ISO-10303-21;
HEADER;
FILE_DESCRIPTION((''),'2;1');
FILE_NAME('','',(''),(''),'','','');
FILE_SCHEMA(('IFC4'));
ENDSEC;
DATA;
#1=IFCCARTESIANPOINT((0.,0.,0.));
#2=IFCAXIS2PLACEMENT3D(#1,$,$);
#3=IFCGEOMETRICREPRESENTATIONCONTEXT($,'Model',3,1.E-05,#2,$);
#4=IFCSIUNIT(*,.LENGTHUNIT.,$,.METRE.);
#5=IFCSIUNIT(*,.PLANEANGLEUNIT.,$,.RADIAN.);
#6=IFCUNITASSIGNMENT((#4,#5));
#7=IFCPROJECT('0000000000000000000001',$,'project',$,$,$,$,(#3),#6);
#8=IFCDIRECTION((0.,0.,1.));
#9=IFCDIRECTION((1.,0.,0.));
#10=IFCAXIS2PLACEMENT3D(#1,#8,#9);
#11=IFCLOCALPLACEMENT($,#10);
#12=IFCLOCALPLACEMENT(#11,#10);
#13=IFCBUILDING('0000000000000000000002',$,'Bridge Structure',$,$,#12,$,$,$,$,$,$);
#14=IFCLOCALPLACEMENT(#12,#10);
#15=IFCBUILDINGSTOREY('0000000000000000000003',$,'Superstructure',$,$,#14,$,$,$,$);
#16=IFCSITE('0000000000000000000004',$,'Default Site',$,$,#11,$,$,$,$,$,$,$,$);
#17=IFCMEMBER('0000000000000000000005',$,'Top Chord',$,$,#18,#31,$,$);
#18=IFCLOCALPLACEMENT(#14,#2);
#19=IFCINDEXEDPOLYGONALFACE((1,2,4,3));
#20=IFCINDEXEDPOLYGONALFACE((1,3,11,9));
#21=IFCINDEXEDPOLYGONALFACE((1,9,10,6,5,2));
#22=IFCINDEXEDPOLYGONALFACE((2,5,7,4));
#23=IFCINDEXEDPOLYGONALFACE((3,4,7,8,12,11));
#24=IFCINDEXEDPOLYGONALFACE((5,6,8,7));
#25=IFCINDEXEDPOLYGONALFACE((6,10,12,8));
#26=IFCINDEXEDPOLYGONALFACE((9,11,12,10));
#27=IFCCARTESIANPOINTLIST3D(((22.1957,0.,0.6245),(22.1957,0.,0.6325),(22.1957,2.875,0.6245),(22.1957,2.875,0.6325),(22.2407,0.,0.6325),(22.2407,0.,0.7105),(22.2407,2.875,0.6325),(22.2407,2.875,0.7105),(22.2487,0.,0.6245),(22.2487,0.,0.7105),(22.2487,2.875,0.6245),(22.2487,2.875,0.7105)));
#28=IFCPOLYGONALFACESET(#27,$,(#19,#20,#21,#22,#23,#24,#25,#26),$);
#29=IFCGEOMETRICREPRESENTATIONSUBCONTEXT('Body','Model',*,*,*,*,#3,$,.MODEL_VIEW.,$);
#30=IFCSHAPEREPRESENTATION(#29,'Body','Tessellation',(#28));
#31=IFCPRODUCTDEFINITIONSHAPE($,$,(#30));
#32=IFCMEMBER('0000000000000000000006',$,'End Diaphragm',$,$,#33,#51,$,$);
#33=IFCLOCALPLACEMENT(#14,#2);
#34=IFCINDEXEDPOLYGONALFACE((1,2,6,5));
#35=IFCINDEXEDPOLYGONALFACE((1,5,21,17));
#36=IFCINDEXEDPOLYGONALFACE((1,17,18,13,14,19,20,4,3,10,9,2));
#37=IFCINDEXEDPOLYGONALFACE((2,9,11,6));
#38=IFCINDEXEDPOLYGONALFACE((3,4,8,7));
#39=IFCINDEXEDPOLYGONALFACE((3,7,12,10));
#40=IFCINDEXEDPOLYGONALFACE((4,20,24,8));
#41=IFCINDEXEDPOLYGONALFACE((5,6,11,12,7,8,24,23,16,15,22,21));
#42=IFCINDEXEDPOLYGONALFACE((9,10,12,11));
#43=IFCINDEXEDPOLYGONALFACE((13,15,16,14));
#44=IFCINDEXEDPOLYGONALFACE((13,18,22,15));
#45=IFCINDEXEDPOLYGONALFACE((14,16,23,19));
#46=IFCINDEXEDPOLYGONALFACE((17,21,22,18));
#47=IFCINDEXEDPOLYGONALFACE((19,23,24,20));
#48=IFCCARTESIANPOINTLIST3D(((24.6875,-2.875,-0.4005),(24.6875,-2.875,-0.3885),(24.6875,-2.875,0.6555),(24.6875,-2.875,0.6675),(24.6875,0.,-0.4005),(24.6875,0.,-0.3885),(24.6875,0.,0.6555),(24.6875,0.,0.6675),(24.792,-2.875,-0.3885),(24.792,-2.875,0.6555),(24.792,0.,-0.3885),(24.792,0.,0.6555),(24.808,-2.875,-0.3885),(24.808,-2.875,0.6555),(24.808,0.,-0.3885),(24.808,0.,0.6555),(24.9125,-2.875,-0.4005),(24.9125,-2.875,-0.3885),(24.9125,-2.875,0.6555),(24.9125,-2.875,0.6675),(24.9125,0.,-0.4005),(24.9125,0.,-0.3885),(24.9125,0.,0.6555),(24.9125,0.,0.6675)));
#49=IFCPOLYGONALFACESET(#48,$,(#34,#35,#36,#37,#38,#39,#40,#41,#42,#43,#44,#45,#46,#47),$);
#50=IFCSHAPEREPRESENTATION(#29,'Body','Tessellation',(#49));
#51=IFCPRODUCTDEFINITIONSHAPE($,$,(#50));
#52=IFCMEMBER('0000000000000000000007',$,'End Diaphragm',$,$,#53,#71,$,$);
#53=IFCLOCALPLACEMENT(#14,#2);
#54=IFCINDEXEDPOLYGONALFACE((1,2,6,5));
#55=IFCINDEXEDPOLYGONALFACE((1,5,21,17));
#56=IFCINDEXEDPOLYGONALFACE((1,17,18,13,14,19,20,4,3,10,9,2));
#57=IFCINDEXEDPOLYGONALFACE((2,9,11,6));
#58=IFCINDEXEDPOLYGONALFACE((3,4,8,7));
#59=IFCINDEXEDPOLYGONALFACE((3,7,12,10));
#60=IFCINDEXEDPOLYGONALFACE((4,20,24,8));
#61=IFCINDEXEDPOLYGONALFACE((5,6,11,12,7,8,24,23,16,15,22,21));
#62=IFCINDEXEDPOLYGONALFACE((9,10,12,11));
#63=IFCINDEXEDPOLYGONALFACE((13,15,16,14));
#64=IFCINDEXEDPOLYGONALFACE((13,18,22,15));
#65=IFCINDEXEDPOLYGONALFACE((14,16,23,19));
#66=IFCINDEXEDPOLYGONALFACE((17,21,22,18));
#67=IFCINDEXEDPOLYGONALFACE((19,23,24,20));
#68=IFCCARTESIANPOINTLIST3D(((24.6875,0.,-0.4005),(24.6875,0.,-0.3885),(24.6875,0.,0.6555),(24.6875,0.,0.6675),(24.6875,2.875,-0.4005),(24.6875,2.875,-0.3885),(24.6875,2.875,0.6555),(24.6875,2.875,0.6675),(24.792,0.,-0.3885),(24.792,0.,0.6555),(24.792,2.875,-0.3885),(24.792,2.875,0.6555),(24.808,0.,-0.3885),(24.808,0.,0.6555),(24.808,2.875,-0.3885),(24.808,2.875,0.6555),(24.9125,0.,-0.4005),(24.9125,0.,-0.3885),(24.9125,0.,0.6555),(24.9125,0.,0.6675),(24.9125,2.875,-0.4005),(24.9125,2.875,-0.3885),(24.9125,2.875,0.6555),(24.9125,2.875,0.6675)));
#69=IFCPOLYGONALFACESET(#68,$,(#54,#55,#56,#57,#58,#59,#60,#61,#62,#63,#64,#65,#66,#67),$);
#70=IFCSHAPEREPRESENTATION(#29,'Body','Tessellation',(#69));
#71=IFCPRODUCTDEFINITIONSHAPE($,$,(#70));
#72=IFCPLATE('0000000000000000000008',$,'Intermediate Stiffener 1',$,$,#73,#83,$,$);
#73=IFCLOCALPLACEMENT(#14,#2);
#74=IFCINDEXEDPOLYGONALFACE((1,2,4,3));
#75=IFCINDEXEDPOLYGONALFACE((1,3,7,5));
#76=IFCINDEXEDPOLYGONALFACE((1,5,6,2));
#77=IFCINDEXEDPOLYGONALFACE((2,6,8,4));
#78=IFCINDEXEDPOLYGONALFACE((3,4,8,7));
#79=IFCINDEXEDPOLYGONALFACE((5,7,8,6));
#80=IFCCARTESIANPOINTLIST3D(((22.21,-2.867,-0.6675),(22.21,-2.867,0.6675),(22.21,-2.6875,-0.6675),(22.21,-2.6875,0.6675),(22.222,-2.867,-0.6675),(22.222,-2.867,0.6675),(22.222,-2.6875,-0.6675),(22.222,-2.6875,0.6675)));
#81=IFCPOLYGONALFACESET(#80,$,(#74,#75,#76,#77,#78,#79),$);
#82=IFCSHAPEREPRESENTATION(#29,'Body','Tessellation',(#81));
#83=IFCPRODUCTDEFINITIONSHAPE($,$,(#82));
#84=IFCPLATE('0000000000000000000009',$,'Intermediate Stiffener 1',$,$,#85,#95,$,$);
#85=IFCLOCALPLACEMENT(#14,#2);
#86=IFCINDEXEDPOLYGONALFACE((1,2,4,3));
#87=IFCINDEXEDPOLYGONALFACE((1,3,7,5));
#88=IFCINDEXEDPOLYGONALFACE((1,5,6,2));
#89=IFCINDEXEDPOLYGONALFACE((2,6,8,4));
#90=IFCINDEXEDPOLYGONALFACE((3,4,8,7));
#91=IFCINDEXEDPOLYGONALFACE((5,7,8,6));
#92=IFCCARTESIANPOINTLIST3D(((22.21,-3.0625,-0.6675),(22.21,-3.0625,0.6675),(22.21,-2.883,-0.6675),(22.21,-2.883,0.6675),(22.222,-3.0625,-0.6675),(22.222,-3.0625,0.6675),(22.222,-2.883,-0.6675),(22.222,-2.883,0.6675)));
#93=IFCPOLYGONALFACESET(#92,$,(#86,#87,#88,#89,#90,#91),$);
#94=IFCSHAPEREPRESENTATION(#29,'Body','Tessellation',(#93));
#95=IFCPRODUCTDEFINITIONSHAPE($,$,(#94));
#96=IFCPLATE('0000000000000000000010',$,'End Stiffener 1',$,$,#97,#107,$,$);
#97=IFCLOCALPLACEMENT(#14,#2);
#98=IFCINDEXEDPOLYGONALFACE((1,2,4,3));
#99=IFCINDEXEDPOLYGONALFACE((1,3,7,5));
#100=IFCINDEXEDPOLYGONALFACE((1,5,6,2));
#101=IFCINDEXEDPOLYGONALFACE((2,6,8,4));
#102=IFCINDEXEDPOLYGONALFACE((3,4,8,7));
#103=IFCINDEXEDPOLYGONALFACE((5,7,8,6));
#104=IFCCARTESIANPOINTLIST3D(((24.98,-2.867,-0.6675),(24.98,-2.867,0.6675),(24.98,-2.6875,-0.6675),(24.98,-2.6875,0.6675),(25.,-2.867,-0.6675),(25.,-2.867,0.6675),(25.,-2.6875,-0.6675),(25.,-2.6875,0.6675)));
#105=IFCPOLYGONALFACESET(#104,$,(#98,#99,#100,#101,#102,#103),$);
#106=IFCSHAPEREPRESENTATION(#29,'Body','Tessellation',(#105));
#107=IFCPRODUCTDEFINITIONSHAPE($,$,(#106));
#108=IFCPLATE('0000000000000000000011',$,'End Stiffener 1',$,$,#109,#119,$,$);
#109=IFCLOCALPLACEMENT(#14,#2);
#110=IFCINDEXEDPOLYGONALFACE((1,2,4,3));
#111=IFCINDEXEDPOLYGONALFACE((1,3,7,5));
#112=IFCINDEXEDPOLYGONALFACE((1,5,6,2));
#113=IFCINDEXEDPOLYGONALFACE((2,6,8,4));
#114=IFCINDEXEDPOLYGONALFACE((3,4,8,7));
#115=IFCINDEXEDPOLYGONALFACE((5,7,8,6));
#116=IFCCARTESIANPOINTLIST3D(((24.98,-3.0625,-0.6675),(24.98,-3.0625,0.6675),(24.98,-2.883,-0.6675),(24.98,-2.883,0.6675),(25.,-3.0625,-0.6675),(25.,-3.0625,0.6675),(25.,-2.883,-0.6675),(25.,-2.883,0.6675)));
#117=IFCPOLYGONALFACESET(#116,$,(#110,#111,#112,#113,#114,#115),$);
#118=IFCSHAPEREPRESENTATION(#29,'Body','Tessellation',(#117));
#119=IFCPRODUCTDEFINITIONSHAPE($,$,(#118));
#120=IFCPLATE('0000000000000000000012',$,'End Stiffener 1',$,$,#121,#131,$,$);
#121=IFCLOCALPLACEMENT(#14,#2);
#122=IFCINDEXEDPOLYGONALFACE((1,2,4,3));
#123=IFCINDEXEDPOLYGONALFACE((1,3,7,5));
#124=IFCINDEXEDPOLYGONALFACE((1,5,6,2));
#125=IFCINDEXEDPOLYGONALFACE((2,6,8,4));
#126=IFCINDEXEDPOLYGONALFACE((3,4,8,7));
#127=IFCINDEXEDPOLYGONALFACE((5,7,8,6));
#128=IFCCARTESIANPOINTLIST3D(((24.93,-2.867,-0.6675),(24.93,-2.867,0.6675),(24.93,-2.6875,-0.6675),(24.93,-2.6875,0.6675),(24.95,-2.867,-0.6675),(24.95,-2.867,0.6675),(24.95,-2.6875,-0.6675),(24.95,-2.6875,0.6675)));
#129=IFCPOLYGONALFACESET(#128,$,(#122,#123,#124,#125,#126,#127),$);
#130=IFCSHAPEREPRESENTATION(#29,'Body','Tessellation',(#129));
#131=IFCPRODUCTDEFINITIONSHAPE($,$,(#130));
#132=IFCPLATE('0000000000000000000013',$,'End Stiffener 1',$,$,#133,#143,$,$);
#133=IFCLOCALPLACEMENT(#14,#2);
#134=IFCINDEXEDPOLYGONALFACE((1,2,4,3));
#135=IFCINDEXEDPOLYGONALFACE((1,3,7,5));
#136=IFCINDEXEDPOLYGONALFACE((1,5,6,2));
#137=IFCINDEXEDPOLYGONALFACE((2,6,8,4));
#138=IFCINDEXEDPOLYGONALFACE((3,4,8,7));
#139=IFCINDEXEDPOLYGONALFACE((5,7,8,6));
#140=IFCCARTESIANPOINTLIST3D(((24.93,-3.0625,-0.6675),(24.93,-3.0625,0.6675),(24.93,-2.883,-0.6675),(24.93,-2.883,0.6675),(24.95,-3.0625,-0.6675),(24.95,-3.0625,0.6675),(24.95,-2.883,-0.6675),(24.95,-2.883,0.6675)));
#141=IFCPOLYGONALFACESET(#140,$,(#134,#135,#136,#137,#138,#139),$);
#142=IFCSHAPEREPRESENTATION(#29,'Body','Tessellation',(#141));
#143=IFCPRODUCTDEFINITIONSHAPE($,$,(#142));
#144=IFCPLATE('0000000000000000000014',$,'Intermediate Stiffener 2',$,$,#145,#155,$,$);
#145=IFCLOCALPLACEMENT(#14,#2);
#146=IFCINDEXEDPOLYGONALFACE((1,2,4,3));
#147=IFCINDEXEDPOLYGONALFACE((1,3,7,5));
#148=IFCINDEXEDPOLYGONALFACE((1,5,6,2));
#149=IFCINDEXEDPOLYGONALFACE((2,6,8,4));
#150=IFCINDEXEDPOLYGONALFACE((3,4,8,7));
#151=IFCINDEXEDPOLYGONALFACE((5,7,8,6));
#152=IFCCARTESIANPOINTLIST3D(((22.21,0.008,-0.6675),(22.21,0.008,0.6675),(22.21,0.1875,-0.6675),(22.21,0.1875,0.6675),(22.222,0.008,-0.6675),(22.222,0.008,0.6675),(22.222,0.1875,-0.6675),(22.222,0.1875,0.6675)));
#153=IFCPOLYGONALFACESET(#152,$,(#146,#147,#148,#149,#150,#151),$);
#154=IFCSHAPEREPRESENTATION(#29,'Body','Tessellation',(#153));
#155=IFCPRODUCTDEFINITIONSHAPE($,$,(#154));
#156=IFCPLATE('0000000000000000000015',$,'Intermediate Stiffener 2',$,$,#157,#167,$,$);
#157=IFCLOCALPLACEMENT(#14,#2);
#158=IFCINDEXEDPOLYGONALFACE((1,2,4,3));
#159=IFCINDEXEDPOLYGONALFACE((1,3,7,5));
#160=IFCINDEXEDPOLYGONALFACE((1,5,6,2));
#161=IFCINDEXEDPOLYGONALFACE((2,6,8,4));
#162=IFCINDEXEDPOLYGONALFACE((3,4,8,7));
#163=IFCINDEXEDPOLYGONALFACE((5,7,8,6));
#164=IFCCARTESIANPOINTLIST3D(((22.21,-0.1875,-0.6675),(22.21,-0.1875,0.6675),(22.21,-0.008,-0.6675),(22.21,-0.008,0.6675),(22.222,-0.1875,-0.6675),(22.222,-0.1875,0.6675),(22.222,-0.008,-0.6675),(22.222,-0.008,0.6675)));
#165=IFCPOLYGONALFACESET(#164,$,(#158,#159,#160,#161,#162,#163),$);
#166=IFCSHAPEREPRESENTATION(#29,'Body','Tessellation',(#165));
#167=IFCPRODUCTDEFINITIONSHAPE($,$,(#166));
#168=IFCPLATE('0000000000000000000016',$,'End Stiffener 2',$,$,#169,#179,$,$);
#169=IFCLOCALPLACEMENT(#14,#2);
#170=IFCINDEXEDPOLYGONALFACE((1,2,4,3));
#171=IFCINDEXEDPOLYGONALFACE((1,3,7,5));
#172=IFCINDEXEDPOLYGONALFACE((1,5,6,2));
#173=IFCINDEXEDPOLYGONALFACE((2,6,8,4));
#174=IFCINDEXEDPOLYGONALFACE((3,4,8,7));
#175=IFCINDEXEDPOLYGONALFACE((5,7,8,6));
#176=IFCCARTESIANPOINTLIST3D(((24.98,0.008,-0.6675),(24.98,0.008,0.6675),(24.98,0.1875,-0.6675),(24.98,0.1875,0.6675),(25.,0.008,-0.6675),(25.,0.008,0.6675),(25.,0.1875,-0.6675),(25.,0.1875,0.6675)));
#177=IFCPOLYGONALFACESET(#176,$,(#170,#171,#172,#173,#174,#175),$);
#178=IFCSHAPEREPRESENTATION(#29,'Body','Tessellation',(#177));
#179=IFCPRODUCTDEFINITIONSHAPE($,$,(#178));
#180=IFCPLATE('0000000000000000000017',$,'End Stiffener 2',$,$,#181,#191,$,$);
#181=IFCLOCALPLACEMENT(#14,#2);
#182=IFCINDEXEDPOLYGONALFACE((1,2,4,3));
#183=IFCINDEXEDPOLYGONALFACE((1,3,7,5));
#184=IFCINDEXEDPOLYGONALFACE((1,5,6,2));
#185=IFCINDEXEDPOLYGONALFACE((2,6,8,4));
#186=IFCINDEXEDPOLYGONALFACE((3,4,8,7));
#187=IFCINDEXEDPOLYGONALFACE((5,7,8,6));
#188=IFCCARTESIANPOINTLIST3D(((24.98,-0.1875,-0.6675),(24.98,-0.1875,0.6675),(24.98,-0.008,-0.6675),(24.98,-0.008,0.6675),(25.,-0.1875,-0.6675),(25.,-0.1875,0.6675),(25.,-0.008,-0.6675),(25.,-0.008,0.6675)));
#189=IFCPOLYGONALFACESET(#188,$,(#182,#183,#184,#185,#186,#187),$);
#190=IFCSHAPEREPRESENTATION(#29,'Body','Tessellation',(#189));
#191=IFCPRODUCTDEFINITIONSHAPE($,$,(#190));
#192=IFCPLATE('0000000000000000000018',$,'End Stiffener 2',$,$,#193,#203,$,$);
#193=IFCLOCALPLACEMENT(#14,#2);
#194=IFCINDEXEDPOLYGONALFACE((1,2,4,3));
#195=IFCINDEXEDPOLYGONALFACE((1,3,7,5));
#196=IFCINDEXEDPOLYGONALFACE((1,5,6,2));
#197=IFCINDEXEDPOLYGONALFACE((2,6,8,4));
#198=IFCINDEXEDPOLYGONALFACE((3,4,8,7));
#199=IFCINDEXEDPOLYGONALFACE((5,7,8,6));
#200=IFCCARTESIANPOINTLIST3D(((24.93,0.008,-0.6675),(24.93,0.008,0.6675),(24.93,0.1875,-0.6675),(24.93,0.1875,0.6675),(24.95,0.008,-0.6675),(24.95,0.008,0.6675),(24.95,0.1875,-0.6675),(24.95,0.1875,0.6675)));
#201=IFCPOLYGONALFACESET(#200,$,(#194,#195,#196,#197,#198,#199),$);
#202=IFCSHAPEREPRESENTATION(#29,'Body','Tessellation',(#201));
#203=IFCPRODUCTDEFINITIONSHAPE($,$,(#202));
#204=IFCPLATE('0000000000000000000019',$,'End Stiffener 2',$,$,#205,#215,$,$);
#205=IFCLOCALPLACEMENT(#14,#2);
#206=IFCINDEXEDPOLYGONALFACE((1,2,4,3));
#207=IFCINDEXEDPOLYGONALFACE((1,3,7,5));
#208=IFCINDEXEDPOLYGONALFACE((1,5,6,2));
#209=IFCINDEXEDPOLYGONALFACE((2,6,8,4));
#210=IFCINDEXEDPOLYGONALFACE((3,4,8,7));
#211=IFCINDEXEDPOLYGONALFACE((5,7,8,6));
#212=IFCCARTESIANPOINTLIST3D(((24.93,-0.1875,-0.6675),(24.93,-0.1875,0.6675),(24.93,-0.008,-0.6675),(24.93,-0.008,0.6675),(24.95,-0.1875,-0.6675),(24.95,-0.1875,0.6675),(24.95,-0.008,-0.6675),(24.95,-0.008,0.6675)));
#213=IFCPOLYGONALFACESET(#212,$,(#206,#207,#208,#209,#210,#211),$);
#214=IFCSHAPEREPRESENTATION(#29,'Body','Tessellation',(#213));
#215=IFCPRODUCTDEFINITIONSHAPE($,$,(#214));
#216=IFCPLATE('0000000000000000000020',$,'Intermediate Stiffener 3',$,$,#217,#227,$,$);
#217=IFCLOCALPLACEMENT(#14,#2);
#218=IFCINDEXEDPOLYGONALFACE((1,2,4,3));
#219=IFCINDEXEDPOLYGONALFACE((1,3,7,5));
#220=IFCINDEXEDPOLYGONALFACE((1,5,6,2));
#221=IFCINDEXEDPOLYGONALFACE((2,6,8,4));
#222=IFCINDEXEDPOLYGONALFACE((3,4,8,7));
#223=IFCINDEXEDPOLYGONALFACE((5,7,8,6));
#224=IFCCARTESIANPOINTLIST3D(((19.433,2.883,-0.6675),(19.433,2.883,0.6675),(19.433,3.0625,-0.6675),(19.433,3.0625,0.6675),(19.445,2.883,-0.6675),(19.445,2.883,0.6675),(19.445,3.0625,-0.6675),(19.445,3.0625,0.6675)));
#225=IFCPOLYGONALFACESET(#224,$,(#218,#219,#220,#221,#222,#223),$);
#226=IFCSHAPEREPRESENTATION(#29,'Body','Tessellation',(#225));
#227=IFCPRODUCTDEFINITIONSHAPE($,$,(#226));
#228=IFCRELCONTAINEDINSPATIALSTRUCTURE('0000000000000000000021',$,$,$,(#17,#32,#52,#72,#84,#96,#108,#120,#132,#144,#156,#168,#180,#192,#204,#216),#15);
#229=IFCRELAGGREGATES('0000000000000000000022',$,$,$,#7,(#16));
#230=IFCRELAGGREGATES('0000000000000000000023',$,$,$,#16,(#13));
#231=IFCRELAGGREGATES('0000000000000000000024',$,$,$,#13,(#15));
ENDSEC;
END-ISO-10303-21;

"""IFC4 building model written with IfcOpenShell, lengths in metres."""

from ifc_helpers import new_model, si_unit, frame, origin, origin_with_axes, origin_2d_with_axis, place, context, subcontext, project, spatial, rectangle, i_section, l_section, extrude, element, save


model = new_model("IFC4")

# Units and contexts
model_context = context("Model", 3, precision=1e-05, world=origin())
body_context = subcontext(model_context, "Body", "Model", "MODEL_VIEW")
ifc_project = project(units=[si_unit("LENGTHUNIT", "METRE"), si_unit("PLANEANGLEUNIT", "RADIAN")], contexts=[model_context])

# Site, building, storey
site_placement = place(None, origin_with_axes())
site = spatial("IfcSite", under=ifc_project, at=site_placement, Name="Default Site")
building_placement = place(site_placement, origin_with_axes())
building = spatial("IfcBuilding", under=site, at=building_placement, Name="Bridge Structure")
storey_placement = place(building_placement, origin_with_axes())
storey = spatial("IfcBuildingStorey", under=building, at=storey_placement, Name="Superstructure")

# Members
for number, where, z_axis, x_axis, name in (
    (1, (22.2222, 0.0, 0.6675), (0.0, 1.0, 0.0), (-1.0, 0.0, 0.0), "Top Chord"),
):
    element("IfcMember", number, at=place(storey_placement, frame(where, z_axis=z_axis, x_axis=x_axis)), inside=storey, Name=name, context=body_context, shape_type="SweptSolid", body=[
        extrude(l_section(Depth=0.086, Width=0.053, Thickness=0.008, at=origin_2d_with_axis()), origin_with_axes(), (0.0, 0.0, 1.0), 2.875),
    ])
for number, where, z_axis, x_axis, name in (
    (2, (24.8, -2.875, 0.1335), (0.0, 1.0, 0.0), (-1.0, 0.0, 0.0), "End Diaphragm"),
    (3, (24.8, 0.0, 0.1335), (0.0, 1.0, 0.0), (-1.0, 0.0, 0.0), "End Diaphragm"),
):
    element("IfcMember", number, at=place(storey_placement, frame(where, z_axis=z_axis, x_axis=x_axis)), inside=storey, Name=name, context=body_context, shape_type="SweptSolid", body=[
        extrude(i_section(OverallWidth=0.225, OverallDepth=1.068, WebThickness=0.016, FlangeThickness=0.012, at=origin_2d_with_axis()), origin_with_axes(), (0.0, 0.0, 1.0), 2.875),
    ])

# Plates
for number, where, z_axis, x_axis, name in (
    (4, (22.216, -2.7772, -0.6675), (0.0, 0.0, 1.0), (1.0, 0.0, 0.0), "Intermediate Stiffener 1"),
    (5, (22.216, -2.9728, -0.6675), (0.0, 0.0, 1.0), (1.0, 0.0, 0.0), "Intermediate Stiffener 1"),
):
    element("IfcPlate", number, at=place(storey_placement, frame(where, z_axis=z_axis, x_axis=x_axis)), inside=storey, Name=name, context=body_context, shape_type="SweptSolid", body=[
        extrude(rectangle(XDim=0.012, YDim=0.1795, at=origin_2d_with_axis()), origin_with_axes(), (0.0, 0.0, 1.0), 1.335),
    ])
for number, where, z_axis, x_axis, name in (
    (6, (24.99, -2.7772, -0.6675), (0.0, 0.0, 1.0), (1.0, 0.0, 0.0), "End Stiffener 1"),
    (7, (24.99, -2.9728, -0.6675), (0.0, 0.0, 1.0), (1.0, 0.0, 0.0), "End Stiffener 1"),
    (8, (24.94, -2.7772, -0.6675), (0.0, 0.0, 1.0), (1.0, 0.0, 0.0), "End Stiffener 1"),
    (9, (24.94, -2.9728, -0.6675), (0.0, 0.0, 1.0), (1.0, 0.0, 0.0), "End Stiffener 1"),
):
    element("IfcPlate", number, at=place(storey_placement, frame(where, z_axis=z_axis, x_axis=x_axis)), inside=storey, Name=name, context=body_context, shape_type="SweptSolid", body=[
        extrude(rectangle(XDim=0.02, YDim=0.1795, at=origin_2d_with_axis()), origin_with_axes(), (0.0, 0.0, 1.0), 1.335),
    ])
for number, where, z_axis, x_axis, name in (
    (10, (22.216, 0.0978, -0.6675), (0.0, 0.0, 1.0), (1.0, 0.0, 0.0), "Intermediate Stiffener 2"),
    (11, (22.216, -0.0978, -0.6675), (0.0, 0.0, 1.0), (1.0, 0.0, 0.0), "Intermediate Stiffener 2"),
):
    element("IfcPlate", number, at=place(storey_placement, frame(where, z_axis=z_axis, x_axis=x_axis)), inside=storey, Name=name, context=body_context, shape_type="SweptSolid", body=[
        extrude(rectangle(XDim=0.012, YDim=0.1795, at=origin_2d_with_axis()), origin_with_axes(), (0.0, 0.0, 1.0), 1.335),
    ])
for number, where, z_axis, x_axis, name in (
    (12, (24.99, 0.0978, -0.6675), (0.0, 0.0, 1.0), (1.0, 0.0, 0.0), "End Stiffener 2"),
    (13, (24.99, -0.0978, -0.6675), (0.0, 0.0, 1.0), (1.0, 0.0, 0.0), "End Stiffener 2"),
    (14, (24.94, 0.0978, -0.6675), (0.0, 0.0, 1.0), (1.0, 0.0, 0.0), "End Stiffener 2"),
    (15, (24.94, -0.0978, -0.6675), (0.0, 0.0, 1.0), (1.0, 0.0, 0.0), "End Stiffener 2"),
):
    element("IfcPlate", number, at=place(storey_placement, frame(where, z_axis=z_axis, x_axis=x_axis)), inside=storey, Name=name, context=body_context, shape_type="SweptSolid", body=[
        extrude(rectangle(XDim=0.02, YDim=0.1795, at=origin_2d_with_axis()), origin_with_axes(), (0.0, 0.0, 1.0), 1.335),
    ])
for number, where, z_axis, x_axis, name in (
    (16, (19.439, 2.9728, -0.6675), (0.0, 0.0, 1.0), (1.0, 0.0, 0.0), "Intermediate Stiffener 3"),
):
    element("IfcPlate", number, at=place(storey_placement, frame(where, z_axis=z_axis, x_axis=x_axis)), inside=storey, Name=name, context=body_context, shape_type="SweptSolid", body=[
        extrude(rectangle(XDim=0.012, YDim=0.1795, at=origin_2d_with_axis()), origin_with_axes(), (0.0, 0.0, 1.0), 1.335),
    ])

save(model, "model.ifc")
